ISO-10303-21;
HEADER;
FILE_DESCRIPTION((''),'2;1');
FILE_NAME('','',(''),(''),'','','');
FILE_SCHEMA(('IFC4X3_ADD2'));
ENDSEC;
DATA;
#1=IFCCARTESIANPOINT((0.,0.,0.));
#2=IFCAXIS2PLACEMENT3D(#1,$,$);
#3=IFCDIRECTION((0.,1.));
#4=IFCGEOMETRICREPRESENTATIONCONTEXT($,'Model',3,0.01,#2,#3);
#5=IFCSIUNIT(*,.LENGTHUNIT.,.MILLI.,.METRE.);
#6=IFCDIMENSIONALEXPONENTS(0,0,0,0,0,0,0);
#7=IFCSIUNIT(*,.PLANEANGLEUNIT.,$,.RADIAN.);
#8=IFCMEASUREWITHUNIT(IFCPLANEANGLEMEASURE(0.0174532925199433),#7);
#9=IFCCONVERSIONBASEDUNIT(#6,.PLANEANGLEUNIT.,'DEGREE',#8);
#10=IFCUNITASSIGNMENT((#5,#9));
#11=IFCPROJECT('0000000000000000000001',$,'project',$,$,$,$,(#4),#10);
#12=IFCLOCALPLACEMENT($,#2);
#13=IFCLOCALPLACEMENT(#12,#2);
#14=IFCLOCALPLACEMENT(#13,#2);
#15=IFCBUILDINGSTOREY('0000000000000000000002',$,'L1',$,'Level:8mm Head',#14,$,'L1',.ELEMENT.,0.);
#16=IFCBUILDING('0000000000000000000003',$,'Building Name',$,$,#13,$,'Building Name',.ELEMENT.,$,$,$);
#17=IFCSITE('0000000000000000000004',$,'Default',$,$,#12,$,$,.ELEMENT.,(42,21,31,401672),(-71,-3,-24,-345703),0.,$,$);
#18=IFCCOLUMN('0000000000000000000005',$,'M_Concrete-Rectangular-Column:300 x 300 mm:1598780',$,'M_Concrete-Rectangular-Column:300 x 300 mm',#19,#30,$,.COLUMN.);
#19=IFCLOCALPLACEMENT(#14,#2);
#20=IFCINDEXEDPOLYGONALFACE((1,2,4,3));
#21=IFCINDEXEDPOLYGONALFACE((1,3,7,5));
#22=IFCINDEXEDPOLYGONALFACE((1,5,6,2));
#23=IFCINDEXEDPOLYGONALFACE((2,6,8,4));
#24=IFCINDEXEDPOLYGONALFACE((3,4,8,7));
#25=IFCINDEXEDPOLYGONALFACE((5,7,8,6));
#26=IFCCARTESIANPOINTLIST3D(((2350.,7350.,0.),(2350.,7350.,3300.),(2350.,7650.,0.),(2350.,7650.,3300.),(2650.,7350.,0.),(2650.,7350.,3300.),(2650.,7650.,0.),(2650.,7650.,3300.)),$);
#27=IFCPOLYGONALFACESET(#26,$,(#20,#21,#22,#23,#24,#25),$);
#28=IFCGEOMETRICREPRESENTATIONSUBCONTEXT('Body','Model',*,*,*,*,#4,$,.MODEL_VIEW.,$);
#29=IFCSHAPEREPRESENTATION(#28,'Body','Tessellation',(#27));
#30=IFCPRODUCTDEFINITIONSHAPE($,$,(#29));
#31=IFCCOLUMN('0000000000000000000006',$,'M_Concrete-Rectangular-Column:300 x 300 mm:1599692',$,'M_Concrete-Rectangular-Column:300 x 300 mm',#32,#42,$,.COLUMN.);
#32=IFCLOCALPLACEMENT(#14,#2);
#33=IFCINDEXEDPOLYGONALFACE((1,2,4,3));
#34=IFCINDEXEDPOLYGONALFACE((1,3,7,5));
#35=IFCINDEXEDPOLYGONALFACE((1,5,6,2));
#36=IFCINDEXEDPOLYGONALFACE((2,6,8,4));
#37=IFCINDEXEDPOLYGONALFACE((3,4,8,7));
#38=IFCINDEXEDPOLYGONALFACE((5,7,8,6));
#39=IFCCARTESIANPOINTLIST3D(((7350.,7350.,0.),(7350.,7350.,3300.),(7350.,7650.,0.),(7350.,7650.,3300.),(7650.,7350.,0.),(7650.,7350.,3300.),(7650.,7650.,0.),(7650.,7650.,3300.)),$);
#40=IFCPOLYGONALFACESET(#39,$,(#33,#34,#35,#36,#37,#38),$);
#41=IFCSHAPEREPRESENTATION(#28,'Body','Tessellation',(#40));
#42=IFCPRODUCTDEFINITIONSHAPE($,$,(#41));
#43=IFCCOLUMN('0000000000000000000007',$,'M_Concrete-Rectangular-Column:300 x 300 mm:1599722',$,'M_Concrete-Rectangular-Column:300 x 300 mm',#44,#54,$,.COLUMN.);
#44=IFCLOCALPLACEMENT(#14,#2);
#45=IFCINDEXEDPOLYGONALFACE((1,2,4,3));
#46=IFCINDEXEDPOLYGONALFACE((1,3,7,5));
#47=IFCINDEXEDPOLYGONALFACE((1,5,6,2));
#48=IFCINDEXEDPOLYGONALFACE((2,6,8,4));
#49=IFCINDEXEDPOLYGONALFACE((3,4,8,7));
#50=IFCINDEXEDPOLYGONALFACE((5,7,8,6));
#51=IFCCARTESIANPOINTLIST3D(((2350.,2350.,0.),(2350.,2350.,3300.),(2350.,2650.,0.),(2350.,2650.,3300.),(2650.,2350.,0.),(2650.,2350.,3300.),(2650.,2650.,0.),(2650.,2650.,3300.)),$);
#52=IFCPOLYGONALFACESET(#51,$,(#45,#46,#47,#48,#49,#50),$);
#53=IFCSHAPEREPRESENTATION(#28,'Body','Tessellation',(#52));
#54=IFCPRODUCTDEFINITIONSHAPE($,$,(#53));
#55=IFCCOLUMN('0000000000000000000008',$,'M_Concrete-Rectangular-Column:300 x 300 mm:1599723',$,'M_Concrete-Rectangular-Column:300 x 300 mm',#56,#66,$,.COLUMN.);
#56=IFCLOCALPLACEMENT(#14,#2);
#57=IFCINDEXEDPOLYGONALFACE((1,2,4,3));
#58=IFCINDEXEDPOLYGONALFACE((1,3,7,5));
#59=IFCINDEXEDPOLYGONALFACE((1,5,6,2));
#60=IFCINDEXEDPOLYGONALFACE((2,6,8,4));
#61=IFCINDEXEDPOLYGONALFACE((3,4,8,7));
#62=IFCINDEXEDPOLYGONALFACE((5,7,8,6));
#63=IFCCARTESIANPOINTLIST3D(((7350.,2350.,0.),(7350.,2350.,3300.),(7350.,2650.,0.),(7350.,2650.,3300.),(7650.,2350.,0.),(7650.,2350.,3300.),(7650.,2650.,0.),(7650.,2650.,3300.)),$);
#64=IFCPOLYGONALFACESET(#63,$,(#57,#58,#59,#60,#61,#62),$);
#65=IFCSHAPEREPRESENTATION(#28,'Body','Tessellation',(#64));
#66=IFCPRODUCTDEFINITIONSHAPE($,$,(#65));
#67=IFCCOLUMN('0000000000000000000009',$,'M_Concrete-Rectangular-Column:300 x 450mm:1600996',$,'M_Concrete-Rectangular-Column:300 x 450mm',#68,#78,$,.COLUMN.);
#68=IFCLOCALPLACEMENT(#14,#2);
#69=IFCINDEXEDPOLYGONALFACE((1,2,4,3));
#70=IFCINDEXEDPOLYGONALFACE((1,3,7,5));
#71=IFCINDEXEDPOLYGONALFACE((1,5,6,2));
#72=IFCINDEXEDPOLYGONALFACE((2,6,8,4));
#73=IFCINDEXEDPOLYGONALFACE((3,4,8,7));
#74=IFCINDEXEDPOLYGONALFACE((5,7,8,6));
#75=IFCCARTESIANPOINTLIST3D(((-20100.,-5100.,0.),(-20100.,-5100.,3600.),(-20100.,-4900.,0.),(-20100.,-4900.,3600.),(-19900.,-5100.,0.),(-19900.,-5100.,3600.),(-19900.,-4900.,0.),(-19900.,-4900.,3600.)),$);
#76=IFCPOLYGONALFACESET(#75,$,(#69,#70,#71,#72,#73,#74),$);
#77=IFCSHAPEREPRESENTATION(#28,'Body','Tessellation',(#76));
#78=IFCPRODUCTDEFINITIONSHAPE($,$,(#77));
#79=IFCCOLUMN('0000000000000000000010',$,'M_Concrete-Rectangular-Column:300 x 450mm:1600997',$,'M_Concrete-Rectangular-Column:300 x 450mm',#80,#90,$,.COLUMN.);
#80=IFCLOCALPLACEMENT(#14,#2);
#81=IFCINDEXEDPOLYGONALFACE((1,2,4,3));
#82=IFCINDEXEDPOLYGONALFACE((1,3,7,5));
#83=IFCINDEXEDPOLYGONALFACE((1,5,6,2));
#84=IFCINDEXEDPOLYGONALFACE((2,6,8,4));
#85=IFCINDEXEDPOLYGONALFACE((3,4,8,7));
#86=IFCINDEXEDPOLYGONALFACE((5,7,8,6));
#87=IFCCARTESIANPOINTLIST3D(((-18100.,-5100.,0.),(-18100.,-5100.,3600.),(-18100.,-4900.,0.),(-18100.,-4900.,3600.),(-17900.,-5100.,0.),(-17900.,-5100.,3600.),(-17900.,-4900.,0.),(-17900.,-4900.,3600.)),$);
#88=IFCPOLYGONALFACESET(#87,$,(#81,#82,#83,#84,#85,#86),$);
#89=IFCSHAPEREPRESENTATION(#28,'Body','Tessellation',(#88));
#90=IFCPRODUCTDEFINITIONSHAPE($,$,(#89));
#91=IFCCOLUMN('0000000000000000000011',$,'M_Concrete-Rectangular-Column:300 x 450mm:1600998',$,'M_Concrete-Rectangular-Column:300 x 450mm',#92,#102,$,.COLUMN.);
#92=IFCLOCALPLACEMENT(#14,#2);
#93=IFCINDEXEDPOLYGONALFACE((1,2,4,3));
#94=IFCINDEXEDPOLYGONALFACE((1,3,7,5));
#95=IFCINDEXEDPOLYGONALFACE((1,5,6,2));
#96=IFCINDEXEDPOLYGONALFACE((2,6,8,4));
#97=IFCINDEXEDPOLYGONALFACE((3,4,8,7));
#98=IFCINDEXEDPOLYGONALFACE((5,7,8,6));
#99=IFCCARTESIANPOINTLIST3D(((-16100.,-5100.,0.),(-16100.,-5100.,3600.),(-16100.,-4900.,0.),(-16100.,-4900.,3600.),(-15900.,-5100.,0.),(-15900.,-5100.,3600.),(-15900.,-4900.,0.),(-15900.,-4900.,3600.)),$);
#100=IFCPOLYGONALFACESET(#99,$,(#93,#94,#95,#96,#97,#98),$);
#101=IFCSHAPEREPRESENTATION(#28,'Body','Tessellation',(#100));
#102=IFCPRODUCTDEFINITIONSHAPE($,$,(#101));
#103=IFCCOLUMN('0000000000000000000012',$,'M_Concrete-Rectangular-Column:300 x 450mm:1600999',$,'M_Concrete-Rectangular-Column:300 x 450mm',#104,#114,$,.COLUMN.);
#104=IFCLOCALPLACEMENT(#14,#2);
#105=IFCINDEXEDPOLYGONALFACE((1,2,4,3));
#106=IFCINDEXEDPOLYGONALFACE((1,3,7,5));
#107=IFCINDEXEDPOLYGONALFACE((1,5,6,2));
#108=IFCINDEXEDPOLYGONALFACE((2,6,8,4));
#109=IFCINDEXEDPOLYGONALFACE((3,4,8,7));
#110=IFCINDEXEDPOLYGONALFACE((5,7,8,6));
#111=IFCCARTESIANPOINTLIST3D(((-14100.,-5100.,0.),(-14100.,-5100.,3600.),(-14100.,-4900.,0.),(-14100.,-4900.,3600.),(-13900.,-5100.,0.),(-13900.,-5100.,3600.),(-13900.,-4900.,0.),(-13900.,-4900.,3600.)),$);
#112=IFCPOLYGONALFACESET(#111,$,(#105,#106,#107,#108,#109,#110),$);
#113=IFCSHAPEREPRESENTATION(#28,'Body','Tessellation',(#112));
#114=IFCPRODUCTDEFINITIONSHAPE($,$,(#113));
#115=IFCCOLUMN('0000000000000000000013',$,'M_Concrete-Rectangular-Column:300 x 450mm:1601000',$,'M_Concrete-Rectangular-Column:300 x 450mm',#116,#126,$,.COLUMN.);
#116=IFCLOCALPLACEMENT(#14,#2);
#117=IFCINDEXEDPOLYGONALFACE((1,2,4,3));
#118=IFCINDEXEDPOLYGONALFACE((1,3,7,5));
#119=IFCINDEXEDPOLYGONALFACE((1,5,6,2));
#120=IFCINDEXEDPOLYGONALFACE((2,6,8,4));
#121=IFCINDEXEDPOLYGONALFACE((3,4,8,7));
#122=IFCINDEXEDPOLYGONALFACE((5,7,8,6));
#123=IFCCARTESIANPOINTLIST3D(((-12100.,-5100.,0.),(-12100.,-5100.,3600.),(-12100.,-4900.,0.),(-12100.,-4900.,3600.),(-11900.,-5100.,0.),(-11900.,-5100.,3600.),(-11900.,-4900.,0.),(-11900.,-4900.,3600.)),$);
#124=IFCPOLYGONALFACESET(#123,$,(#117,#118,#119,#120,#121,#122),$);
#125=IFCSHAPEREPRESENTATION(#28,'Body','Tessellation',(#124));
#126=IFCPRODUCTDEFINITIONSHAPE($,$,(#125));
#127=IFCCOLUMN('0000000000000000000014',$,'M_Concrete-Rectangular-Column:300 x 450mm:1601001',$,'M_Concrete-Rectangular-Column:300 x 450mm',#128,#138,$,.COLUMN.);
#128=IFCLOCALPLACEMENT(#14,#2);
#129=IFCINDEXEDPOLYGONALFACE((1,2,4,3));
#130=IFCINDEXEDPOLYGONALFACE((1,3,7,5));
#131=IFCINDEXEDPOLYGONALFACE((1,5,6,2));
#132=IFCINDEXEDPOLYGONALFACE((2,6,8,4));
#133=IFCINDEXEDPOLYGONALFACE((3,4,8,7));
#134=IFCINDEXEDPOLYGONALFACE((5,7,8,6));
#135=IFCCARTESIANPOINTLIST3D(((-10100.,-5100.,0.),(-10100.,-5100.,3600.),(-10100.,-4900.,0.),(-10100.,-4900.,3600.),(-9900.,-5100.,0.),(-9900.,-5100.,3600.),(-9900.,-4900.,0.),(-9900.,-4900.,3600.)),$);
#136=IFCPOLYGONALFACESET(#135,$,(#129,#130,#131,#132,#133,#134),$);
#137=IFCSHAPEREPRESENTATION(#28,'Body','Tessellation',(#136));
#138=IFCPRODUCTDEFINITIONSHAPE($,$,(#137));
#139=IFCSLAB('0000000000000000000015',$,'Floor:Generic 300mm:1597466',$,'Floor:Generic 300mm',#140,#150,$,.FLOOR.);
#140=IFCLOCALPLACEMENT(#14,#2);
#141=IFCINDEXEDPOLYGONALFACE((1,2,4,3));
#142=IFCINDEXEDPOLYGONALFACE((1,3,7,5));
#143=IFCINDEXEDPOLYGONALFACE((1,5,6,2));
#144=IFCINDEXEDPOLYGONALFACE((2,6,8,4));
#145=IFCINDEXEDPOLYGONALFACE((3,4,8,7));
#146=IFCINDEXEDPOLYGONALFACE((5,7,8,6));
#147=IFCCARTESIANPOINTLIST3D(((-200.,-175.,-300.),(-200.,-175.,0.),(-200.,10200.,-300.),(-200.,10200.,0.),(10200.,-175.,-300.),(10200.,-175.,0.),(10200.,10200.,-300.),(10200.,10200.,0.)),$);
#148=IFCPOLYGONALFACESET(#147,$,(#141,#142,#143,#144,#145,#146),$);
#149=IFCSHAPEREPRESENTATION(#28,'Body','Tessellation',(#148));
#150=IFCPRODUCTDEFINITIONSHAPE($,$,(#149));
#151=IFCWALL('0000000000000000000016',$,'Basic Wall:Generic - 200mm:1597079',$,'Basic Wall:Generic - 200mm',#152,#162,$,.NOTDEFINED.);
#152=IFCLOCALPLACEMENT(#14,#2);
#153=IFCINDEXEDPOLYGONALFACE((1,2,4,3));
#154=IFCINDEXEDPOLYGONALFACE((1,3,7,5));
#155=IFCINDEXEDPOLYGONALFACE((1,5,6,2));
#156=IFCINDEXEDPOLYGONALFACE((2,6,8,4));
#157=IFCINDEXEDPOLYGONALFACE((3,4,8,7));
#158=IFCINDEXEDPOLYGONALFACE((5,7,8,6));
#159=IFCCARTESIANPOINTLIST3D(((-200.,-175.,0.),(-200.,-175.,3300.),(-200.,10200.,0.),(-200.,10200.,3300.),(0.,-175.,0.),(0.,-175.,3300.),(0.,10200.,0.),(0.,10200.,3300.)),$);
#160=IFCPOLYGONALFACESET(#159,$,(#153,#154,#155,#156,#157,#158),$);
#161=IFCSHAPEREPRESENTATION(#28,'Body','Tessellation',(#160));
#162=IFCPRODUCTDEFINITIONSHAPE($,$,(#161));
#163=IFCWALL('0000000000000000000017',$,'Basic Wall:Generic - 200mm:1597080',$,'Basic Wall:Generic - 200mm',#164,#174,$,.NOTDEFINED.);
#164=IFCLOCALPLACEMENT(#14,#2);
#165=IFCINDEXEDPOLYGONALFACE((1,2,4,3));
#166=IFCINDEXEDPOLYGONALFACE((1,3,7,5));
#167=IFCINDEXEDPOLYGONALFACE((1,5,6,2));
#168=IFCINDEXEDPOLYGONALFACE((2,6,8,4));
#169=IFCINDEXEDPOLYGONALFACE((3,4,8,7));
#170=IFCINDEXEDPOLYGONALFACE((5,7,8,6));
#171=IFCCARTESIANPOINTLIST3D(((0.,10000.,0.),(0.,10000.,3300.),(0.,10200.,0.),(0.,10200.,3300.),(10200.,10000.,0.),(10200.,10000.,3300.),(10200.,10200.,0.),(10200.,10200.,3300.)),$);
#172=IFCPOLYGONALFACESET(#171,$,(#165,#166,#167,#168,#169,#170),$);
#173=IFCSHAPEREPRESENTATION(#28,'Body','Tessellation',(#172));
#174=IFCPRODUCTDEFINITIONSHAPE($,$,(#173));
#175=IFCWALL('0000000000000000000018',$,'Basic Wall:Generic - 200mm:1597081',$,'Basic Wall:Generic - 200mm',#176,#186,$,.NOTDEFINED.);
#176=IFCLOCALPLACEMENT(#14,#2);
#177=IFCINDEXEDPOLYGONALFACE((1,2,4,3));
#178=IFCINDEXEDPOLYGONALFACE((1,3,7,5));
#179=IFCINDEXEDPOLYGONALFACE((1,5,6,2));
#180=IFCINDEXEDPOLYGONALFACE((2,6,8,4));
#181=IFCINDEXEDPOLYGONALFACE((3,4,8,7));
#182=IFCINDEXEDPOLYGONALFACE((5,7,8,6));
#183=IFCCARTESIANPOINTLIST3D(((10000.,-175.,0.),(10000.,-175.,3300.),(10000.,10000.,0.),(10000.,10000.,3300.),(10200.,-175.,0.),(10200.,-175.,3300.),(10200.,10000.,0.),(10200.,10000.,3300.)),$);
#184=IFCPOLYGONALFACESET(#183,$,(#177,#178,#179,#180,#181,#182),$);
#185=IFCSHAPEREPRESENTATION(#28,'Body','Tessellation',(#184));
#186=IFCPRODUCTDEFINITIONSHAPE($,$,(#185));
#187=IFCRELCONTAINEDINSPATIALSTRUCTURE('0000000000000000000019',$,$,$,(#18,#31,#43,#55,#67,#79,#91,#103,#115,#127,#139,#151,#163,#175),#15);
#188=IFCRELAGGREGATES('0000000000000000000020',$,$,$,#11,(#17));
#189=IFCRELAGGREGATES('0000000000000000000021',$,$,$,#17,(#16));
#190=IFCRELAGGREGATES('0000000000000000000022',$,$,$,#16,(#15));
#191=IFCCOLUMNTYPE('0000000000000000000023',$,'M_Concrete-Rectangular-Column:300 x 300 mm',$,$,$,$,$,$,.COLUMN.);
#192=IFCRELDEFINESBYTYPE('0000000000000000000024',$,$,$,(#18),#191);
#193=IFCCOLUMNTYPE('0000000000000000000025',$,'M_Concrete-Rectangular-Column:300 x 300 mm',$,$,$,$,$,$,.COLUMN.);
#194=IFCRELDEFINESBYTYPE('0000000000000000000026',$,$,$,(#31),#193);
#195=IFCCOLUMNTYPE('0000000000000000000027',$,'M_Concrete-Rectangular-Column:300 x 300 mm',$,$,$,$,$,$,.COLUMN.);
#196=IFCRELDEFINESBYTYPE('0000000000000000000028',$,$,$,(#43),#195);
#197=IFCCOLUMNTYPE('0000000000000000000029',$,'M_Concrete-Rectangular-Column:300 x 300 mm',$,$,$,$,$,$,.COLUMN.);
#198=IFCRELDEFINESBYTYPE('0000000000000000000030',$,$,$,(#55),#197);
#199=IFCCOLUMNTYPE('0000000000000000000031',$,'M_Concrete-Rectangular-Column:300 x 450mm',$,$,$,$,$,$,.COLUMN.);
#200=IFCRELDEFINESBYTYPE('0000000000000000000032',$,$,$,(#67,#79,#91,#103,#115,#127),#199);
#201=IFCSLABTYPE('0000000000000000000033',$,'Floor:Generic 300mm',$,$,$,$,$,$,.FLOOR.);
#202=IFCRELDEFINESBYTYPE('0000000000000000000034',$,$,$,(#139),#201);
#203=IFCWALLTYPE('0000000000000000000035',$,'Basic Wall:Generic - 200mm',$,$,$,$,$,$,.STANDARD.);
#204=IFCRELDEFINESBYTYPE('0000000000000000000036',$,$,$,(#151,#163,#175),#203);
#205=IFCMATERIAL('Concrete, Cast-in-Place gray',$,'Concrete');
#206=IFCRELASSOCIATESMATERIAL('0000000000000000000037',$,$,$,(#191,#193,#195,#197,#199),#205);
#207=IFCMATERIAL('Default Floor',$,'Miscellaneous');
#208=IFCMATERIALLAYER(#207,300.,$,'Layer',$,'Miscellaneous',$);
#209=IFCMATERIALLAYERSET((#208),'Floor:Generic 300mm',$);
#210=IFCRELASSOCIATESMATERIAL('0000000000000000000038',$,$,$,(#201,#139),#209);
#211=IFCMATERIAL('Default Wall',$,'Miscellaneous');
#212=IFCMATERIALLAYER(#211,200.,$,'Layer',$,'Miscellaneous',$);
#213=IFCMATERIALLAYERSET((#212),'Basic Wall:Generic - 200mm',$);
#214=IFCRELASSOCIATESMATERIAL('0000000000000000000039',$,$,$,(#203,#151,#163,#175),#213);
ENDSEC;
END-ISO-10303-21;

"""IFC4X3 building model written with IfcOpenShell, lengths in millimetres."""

from ifc_helpers import new_model, entity, si_unit, converted_unit, direction, frame, frame_2d, origin, origin_2d_with_axis, place, context, subcontext, project, spatial, rectangle, extrude, source, transform, mapped, material, layer, layer_set, layer_usage, material_profile, profile_set, type_object, type_shapes, element, save


model = new_model("IFC4X3")

# Units and contexts
model_context = context("Model", 3, precision=0.01, world=origin(), true_north=direction((0.0, 1.0)))
body_context = subcontext(model_context, "Body", "Model", "MODEL_VIEW")
ifc_project = project(units=[si_unit("LENGTHUNIT", "METRE", prefix="MILLI"), converted_unit("PLANEANGLEUNIT", "DEGREE", entity("IfcPlaneAngleMeasure", 0.0174532925199433), si_unit("PLANEANGLEUNIT", "RADIAN"), dimensions=[0, 0, 0, 0, 0, 0, 0])], contexts=[model_context])

# Site, building, storey
site_placement = place(None, origin())
site = spatial("IfcSite", under=ifc_project, at=site_placement, Name="Default", CompositionType="ELEMENT", RefLatitude=(42, 21, 31, 401672), RefLongitude=(-71, -3, -24, -345703), RefElevation=0.0)
building_placement = place(site_placement, origin())
building = spatial("IfcBuilding", under=site, at=building_placement, Name="Building Name", LongName="Building Name", CompositionType="ELEMENT")
storey_placement = place(building_placement, origin())
storey = spatial("IfcBuildingStorey", under=building, at=storey_placement, Name="L1", ObjectType="Level:8mm Head", LongName="L1", CompositionType="ELEMENT", Elevation=0.0)

# Columns
ifc_material_1 = material(Name="Concrete, Cast-in-Place gray", Category="Concrete")
ifc_material_profile_1 = material_profile(ifc_material_1, rectangle(XDim=300.0, YDim=300.0, at=origin_2d_with_axis()), Name="300 x 300 mm")
ifc_profile_set_1 = profile_set([ifc_material_profile_1], Name="300 x 300 mm")
column_type_1 = type_object("IfcColumnType", Name="M_Concrete-Rectangular-Column:300 x 300 mm", PredefinedType="COLUMN", material=ifc_profile_set_1)
shared_shape_1 = source(origin(), body_context, "Body", "SweptSolid", [
    extrude(rectangle(XDim=300.0, YDim=300.0, at=origin_2d_with_axis()), frame((2500.0, 7500.0, 0.0)), (0.0, 0.0, 1.0), 3300.0),
])
type_shapes(column_type_1, [shared_shape_1])
column_1_placement = place(storey_placement, origin())
element("IfcColumn", 1, at=column_1_placement, inside=storey, type_object=column_type_1, Name="M_Concrete-Rectangular-Column:300 x 300 mm:1598780", ObjectType="M_Concrete-Rectangular-Column:300 x 300 mm", PredefinedType="COLUMN", context=body_context, shape_type="MappedRepresentation", body=[
    mapped(shared_shape_1, transform((0.0, 0.0, 0.0), scale=1.0)),
])
column_type_2 = type_object("IfcColumnType", Name="M_Concrete-Rectangular-Column:300 x 300 mm", PredefinedType="COLUMN", material=ifc_profile_set_1)
shared_shape_2 = source(origin(), body_context, "Body", "SweptSolid", [
    extrude(rectangle(XDim=300.0, YDim=300.0, at=origin_2d_with_axis()), frame((7500.0, 7500.0, 0.0)), (0.0, 0.0, 1.0), 3300.0),
])
type_shapes(column_type_2, [shared_shape_2])
column_2_placement = place(storey_placement, origin())
element("IfcColumn", 2, at=column_2_placement, inside=storey, type_object=column_type_2, Name="M_Concrete-Rectangular-Column:300 x 300 mm:1599692", ObjectType="M_Concrete-Rectangular-Column:300 x 300 mm", PredefinedType="COLUMN", context=body_context, shape_type="MappedRepresentation", body=[
    mapped(shared_shape_2, transform((0.0, 0.0, 0.0), scale=1.0)),
])
column_type_3 = type_object("IfcColumnType", Name="M_Concrete-Rectangular-Column:300 x 300 mm", PredefinedType="COLUMN", material=ifc_profile_set_1)
shared_shape_3 = source(origin(), body_context, "Body", "SweptSolid", [
    extrude(rectangle(XDim=300.0, YDim=300.0, at=origin_2d_with_axis()), frame((2500.0, 2500.0, 0.0)), (0.0, 0.0, 1.0), 3300.0),
])
type_shapes(column_type_3, [shared_shape_3])
column_3_placement = place(storey_placement, origin())
element("IfcColumn", 3, at=column_3_placement, inside=storey, type_object=column_type_3, Name="M_Concrete-Rectangular-Column:300 x 300 mm:1599722", ObjectType="M_Concrete-Rectangular-Column:300 x 300 mm", PredefinedType="COLUMN", context=body_context, shape_type="MappedRepresentation", body=[
    mapped(shared_shape_3, transform((0.0, 0.0, 0.0), scale=1.0)),
])
column_type_4 = type_object("IfcColumnType", Name="M_Concrete-Rectangular-Column:300 x 300 mm", PredefinedType="COLUMN", material=ifc_profile_set_1)
shared_shape_4 = source(origin(), body_context, "Body", "SweptSolid", [
    extrude(rectangle(XDim=300.0, YDim=300.0, at=origin_2d_with_axis()), frame((7500.0, 2500.0, 0.0)), (0.0, 0.0, 1.0), 3300.0),
])
type_shapes(column_type_4, [shared_shape_4])
column_4_placement = place(storey_placement, origin())
element("IfcColumn", 4, at=column_4_placement, inside=storey, type_object=column_type_4, Name="M_Concrete-Rectangular-Column:300 x 300 mm:1599723", ObjectType="M_Concrete-Rectangular-Column:300 x 300 mm", PredefinedType="COLUMN", context=body_context, shape_type="MappedRepresentation", body=[
    mapped(shared_shape_4, transform((0.0, 0.0, 0.0), scale=1.0)),
])
ifc_material_profile_2 = material_profile(ifc_material_1, rectangle(XDim=200.0, YDim=200.0, at=origin_2d_with_axis()), Name="300 x 450mm")
ifc_profile_set_2 = profile_set([ifc_material_profile_2], Name="300 x 450mm")
column_type_5 = type_object("IfcColumnType", Name="M_Concrete-Rectangular-Column:300 x 450mm", PredefinedType="COLUMN", material=ifc_profile_set_2)
shared_shape_5 = source(origin(), body_context, "Body", "SweptSolid", [
    extrude(rectangle(XDim=200.0, YDim=200.0, at=origin_2d_with_axis()), frame((0.0, 0.0, 0.0), z_axis=(0.0, 0.0, 1.0), x_axis=(-1.0, 0.0, 0.0)), (0.0, 0.0, 1.0), 3600.0),
])
type_shapes(column_type_5, [shared_shape_5])
for number, where, z_axis, x_axis, name in (
    (5, (-20000.0, -5000.0, 0.0), (0.0, 0.0, 1.0), (0.0, -1.0, 0.0), "M_Concrete-Rectangular-Column:300 x 450mm:1600996"),
    (6, (-18000.0, -5000.0, 0.0), (0.0, 0.0, 1.0), (0.0, -1.0, 0.0), "M_Concrete-Rectangular-Column:300 x 450mm:1600997"),
    (7, (-16000.0, -5000.0, 0.0), (0.0, 0.0, 1.0), (0.0, -1.0, 0.0), "M_Concrete-Rectangular-Column:300 x 450mm:1600998"),
    (8, (-14000.0, -5000.0, 0.0), (0.0, 0.0, 1.0), (0.0, -1.0, 0.0), "M_Concrete-Rectangular-Column:300 x 450mm:1600999"),
    (9, (-12000.0, -5000.0, 0.0), (0.0, 0.0, 1.0), (0.0, -1.0, 0.0), "M_Concrete-Rectangular-Column:300 x 450mm:1601000"),
    (10, (-10000.0, -5000.0, 0.0), (0.0, 0.0, 1.0), (0.0, -1.0, 0.0), "M_Concrete-Rectangular-Column:300 x 450mm:1601001"),
):
    element("IfcColumn", number, at=place(storey_placement, frame(where, z_axis=z_axis, x_axis=x_axis)), inside=storey, type_object=column_type_5, Name=name, ObjectType="M_Concrete-Rectangular-Column:300 x 450mm", PredefinedType="COLUMN", context=body_context, shape_type="MappedRepresentation", body=[
        mapped(shared_shape_5, transform((0.0, 0.0, 0.0), scale=1.0)),
    ])

# Slab
ifc_material_2 = material(Name="Default Floor", Category="Miscellaneous")
ifc_layer_1 = layer(ifc_material_2, 300.0, Name="Layer", Category="Miscellaneous")
ifc_layer_set_1 = layer_set([ifc_layer_1], Name="Floor:Generic 300mm")
ifc_layer_usage = layer_usage(ifc_layer_set_1, "AXIS3", "POSITIVE", 0.0)
slab_type = type_object("IfcSlabType", Name="Floor:Generic 300mm", PredefinedType="FLOOR", material=ifc_layer_set_1)
slab_placement = place(storey_placement, origin())
element("IfcSlab", 11, at=slab_placement, inside=storey, type_object=slab_type, material=ifc_layer_usage, Name="Floor:Generic 300mm:1597466", ObjectType="Floor:Generic 300mm", PredefinedType="FLOOR", context=body_context, shape_type="SweptSolid", body=[
    extrude(rectangle(XDim=10375.0, YDim=10400.0, at=origin_2d_with_axis()), frame((5000.0, 5012.5, 0.0), z_axis=(0.0, 0.0, -1.0), x_axis=(0.0, 1.0, 0.0)), (0.0, 0.0, 1.0), 300.0),
])

# Walls
ifc_material_3 = material(Name="Default Wall", Category="Miscellaneous")
ifc_layer_2 = layer(ifc_material_3, 200.0, Name="Layer", Category="Miscellaneous")
ifc_layer_set_2 = layer_set([ifc_layer_2], Name="Basic Wall:Generic - 200mm")
wall_type_1 = type_object("IfcWallType", Name="Basic Wall:Generic - 200mm", PredefinedType="STANDARD", material=ifc_layer_set_2)
wall_1_placement = place(storey_placement, frame((-100.0, 10200.0, 0.0), z_axis=(0.0, 0.0, 1.0), x_axis=(0.0, -1.0, 0.0)))
element("IfcWall", 12, at=wall_1_placement, inside=storey, type_object=wall_type_1, material=ifc_layer_set_2, Name="Basic Wall:Generic - 200mm:1597079", ObjectType="Basic Wall:Generic - 200mm", PredefinedType="NOTDEFINED", context=body_context, shape_type="SweptSolid", body=[
    extrude(rectangle(XDim=10375.0, YDim=200.0, at=frame_2d((5187.5, 0.0), x_axis=(-1.0, 0.0))), origin(), (0.0, 0.0, 1.0), 3300.0),
])
wall_2_placement = place(storey_placement, frame((10200.0, 10100.0, 0.0), z_axis=(0.0, 0.0, 1.0), x_axis=(-1.0, 0.0, 0.0)))
element("IfcWall", 13, at=wall_2_placement, inside=storey, type_object=wall_type_1, material=ifc_layer_set_2, Name="Basic Wall:Generic - 200mm:1597080", ObjectType="Basic Wall:Generic - 200mm", PredefinedType="NOTDEFINED", context=body_context, shape_type="SweptSolid", body=[
    extrude(rectangle(XDim=10200.0, YDim=200.0, at=frame_2d((5100.0, 0.0), x_axis=(-1.0, 0.0))), origin(), (0.0, 0.0, 1.0), 3300.0),
])
wall_3_placement = place(storey_placement, frame((10100.0, -175.0, 0.0), z_axis=(0.0, 0.0, 1.0), x_axis=(0.0, 1.0, 0.0)))
element("IfcWall", 14, at=wall_3_placement, inside=storey, type_object=wall_type_1, material=ifc_layer_set_2, Name="Basic Wall:Generic - 200mm:1597081", ObjectType="Basic Wall:Generic - 200mm", PredefinedType="NOTDEFINED", context=body_context, shape_type="SweptSolid", body=[
    extrude(rectangle(XDim=10175.0, YDim=200.0, at=frame_2d((5087.5, 0.0), x_axis=(-1.0, 0.0))), origin(), (0.0, 0.0, 1.0), 3300.0),
])

save(model, "model.ifc")
